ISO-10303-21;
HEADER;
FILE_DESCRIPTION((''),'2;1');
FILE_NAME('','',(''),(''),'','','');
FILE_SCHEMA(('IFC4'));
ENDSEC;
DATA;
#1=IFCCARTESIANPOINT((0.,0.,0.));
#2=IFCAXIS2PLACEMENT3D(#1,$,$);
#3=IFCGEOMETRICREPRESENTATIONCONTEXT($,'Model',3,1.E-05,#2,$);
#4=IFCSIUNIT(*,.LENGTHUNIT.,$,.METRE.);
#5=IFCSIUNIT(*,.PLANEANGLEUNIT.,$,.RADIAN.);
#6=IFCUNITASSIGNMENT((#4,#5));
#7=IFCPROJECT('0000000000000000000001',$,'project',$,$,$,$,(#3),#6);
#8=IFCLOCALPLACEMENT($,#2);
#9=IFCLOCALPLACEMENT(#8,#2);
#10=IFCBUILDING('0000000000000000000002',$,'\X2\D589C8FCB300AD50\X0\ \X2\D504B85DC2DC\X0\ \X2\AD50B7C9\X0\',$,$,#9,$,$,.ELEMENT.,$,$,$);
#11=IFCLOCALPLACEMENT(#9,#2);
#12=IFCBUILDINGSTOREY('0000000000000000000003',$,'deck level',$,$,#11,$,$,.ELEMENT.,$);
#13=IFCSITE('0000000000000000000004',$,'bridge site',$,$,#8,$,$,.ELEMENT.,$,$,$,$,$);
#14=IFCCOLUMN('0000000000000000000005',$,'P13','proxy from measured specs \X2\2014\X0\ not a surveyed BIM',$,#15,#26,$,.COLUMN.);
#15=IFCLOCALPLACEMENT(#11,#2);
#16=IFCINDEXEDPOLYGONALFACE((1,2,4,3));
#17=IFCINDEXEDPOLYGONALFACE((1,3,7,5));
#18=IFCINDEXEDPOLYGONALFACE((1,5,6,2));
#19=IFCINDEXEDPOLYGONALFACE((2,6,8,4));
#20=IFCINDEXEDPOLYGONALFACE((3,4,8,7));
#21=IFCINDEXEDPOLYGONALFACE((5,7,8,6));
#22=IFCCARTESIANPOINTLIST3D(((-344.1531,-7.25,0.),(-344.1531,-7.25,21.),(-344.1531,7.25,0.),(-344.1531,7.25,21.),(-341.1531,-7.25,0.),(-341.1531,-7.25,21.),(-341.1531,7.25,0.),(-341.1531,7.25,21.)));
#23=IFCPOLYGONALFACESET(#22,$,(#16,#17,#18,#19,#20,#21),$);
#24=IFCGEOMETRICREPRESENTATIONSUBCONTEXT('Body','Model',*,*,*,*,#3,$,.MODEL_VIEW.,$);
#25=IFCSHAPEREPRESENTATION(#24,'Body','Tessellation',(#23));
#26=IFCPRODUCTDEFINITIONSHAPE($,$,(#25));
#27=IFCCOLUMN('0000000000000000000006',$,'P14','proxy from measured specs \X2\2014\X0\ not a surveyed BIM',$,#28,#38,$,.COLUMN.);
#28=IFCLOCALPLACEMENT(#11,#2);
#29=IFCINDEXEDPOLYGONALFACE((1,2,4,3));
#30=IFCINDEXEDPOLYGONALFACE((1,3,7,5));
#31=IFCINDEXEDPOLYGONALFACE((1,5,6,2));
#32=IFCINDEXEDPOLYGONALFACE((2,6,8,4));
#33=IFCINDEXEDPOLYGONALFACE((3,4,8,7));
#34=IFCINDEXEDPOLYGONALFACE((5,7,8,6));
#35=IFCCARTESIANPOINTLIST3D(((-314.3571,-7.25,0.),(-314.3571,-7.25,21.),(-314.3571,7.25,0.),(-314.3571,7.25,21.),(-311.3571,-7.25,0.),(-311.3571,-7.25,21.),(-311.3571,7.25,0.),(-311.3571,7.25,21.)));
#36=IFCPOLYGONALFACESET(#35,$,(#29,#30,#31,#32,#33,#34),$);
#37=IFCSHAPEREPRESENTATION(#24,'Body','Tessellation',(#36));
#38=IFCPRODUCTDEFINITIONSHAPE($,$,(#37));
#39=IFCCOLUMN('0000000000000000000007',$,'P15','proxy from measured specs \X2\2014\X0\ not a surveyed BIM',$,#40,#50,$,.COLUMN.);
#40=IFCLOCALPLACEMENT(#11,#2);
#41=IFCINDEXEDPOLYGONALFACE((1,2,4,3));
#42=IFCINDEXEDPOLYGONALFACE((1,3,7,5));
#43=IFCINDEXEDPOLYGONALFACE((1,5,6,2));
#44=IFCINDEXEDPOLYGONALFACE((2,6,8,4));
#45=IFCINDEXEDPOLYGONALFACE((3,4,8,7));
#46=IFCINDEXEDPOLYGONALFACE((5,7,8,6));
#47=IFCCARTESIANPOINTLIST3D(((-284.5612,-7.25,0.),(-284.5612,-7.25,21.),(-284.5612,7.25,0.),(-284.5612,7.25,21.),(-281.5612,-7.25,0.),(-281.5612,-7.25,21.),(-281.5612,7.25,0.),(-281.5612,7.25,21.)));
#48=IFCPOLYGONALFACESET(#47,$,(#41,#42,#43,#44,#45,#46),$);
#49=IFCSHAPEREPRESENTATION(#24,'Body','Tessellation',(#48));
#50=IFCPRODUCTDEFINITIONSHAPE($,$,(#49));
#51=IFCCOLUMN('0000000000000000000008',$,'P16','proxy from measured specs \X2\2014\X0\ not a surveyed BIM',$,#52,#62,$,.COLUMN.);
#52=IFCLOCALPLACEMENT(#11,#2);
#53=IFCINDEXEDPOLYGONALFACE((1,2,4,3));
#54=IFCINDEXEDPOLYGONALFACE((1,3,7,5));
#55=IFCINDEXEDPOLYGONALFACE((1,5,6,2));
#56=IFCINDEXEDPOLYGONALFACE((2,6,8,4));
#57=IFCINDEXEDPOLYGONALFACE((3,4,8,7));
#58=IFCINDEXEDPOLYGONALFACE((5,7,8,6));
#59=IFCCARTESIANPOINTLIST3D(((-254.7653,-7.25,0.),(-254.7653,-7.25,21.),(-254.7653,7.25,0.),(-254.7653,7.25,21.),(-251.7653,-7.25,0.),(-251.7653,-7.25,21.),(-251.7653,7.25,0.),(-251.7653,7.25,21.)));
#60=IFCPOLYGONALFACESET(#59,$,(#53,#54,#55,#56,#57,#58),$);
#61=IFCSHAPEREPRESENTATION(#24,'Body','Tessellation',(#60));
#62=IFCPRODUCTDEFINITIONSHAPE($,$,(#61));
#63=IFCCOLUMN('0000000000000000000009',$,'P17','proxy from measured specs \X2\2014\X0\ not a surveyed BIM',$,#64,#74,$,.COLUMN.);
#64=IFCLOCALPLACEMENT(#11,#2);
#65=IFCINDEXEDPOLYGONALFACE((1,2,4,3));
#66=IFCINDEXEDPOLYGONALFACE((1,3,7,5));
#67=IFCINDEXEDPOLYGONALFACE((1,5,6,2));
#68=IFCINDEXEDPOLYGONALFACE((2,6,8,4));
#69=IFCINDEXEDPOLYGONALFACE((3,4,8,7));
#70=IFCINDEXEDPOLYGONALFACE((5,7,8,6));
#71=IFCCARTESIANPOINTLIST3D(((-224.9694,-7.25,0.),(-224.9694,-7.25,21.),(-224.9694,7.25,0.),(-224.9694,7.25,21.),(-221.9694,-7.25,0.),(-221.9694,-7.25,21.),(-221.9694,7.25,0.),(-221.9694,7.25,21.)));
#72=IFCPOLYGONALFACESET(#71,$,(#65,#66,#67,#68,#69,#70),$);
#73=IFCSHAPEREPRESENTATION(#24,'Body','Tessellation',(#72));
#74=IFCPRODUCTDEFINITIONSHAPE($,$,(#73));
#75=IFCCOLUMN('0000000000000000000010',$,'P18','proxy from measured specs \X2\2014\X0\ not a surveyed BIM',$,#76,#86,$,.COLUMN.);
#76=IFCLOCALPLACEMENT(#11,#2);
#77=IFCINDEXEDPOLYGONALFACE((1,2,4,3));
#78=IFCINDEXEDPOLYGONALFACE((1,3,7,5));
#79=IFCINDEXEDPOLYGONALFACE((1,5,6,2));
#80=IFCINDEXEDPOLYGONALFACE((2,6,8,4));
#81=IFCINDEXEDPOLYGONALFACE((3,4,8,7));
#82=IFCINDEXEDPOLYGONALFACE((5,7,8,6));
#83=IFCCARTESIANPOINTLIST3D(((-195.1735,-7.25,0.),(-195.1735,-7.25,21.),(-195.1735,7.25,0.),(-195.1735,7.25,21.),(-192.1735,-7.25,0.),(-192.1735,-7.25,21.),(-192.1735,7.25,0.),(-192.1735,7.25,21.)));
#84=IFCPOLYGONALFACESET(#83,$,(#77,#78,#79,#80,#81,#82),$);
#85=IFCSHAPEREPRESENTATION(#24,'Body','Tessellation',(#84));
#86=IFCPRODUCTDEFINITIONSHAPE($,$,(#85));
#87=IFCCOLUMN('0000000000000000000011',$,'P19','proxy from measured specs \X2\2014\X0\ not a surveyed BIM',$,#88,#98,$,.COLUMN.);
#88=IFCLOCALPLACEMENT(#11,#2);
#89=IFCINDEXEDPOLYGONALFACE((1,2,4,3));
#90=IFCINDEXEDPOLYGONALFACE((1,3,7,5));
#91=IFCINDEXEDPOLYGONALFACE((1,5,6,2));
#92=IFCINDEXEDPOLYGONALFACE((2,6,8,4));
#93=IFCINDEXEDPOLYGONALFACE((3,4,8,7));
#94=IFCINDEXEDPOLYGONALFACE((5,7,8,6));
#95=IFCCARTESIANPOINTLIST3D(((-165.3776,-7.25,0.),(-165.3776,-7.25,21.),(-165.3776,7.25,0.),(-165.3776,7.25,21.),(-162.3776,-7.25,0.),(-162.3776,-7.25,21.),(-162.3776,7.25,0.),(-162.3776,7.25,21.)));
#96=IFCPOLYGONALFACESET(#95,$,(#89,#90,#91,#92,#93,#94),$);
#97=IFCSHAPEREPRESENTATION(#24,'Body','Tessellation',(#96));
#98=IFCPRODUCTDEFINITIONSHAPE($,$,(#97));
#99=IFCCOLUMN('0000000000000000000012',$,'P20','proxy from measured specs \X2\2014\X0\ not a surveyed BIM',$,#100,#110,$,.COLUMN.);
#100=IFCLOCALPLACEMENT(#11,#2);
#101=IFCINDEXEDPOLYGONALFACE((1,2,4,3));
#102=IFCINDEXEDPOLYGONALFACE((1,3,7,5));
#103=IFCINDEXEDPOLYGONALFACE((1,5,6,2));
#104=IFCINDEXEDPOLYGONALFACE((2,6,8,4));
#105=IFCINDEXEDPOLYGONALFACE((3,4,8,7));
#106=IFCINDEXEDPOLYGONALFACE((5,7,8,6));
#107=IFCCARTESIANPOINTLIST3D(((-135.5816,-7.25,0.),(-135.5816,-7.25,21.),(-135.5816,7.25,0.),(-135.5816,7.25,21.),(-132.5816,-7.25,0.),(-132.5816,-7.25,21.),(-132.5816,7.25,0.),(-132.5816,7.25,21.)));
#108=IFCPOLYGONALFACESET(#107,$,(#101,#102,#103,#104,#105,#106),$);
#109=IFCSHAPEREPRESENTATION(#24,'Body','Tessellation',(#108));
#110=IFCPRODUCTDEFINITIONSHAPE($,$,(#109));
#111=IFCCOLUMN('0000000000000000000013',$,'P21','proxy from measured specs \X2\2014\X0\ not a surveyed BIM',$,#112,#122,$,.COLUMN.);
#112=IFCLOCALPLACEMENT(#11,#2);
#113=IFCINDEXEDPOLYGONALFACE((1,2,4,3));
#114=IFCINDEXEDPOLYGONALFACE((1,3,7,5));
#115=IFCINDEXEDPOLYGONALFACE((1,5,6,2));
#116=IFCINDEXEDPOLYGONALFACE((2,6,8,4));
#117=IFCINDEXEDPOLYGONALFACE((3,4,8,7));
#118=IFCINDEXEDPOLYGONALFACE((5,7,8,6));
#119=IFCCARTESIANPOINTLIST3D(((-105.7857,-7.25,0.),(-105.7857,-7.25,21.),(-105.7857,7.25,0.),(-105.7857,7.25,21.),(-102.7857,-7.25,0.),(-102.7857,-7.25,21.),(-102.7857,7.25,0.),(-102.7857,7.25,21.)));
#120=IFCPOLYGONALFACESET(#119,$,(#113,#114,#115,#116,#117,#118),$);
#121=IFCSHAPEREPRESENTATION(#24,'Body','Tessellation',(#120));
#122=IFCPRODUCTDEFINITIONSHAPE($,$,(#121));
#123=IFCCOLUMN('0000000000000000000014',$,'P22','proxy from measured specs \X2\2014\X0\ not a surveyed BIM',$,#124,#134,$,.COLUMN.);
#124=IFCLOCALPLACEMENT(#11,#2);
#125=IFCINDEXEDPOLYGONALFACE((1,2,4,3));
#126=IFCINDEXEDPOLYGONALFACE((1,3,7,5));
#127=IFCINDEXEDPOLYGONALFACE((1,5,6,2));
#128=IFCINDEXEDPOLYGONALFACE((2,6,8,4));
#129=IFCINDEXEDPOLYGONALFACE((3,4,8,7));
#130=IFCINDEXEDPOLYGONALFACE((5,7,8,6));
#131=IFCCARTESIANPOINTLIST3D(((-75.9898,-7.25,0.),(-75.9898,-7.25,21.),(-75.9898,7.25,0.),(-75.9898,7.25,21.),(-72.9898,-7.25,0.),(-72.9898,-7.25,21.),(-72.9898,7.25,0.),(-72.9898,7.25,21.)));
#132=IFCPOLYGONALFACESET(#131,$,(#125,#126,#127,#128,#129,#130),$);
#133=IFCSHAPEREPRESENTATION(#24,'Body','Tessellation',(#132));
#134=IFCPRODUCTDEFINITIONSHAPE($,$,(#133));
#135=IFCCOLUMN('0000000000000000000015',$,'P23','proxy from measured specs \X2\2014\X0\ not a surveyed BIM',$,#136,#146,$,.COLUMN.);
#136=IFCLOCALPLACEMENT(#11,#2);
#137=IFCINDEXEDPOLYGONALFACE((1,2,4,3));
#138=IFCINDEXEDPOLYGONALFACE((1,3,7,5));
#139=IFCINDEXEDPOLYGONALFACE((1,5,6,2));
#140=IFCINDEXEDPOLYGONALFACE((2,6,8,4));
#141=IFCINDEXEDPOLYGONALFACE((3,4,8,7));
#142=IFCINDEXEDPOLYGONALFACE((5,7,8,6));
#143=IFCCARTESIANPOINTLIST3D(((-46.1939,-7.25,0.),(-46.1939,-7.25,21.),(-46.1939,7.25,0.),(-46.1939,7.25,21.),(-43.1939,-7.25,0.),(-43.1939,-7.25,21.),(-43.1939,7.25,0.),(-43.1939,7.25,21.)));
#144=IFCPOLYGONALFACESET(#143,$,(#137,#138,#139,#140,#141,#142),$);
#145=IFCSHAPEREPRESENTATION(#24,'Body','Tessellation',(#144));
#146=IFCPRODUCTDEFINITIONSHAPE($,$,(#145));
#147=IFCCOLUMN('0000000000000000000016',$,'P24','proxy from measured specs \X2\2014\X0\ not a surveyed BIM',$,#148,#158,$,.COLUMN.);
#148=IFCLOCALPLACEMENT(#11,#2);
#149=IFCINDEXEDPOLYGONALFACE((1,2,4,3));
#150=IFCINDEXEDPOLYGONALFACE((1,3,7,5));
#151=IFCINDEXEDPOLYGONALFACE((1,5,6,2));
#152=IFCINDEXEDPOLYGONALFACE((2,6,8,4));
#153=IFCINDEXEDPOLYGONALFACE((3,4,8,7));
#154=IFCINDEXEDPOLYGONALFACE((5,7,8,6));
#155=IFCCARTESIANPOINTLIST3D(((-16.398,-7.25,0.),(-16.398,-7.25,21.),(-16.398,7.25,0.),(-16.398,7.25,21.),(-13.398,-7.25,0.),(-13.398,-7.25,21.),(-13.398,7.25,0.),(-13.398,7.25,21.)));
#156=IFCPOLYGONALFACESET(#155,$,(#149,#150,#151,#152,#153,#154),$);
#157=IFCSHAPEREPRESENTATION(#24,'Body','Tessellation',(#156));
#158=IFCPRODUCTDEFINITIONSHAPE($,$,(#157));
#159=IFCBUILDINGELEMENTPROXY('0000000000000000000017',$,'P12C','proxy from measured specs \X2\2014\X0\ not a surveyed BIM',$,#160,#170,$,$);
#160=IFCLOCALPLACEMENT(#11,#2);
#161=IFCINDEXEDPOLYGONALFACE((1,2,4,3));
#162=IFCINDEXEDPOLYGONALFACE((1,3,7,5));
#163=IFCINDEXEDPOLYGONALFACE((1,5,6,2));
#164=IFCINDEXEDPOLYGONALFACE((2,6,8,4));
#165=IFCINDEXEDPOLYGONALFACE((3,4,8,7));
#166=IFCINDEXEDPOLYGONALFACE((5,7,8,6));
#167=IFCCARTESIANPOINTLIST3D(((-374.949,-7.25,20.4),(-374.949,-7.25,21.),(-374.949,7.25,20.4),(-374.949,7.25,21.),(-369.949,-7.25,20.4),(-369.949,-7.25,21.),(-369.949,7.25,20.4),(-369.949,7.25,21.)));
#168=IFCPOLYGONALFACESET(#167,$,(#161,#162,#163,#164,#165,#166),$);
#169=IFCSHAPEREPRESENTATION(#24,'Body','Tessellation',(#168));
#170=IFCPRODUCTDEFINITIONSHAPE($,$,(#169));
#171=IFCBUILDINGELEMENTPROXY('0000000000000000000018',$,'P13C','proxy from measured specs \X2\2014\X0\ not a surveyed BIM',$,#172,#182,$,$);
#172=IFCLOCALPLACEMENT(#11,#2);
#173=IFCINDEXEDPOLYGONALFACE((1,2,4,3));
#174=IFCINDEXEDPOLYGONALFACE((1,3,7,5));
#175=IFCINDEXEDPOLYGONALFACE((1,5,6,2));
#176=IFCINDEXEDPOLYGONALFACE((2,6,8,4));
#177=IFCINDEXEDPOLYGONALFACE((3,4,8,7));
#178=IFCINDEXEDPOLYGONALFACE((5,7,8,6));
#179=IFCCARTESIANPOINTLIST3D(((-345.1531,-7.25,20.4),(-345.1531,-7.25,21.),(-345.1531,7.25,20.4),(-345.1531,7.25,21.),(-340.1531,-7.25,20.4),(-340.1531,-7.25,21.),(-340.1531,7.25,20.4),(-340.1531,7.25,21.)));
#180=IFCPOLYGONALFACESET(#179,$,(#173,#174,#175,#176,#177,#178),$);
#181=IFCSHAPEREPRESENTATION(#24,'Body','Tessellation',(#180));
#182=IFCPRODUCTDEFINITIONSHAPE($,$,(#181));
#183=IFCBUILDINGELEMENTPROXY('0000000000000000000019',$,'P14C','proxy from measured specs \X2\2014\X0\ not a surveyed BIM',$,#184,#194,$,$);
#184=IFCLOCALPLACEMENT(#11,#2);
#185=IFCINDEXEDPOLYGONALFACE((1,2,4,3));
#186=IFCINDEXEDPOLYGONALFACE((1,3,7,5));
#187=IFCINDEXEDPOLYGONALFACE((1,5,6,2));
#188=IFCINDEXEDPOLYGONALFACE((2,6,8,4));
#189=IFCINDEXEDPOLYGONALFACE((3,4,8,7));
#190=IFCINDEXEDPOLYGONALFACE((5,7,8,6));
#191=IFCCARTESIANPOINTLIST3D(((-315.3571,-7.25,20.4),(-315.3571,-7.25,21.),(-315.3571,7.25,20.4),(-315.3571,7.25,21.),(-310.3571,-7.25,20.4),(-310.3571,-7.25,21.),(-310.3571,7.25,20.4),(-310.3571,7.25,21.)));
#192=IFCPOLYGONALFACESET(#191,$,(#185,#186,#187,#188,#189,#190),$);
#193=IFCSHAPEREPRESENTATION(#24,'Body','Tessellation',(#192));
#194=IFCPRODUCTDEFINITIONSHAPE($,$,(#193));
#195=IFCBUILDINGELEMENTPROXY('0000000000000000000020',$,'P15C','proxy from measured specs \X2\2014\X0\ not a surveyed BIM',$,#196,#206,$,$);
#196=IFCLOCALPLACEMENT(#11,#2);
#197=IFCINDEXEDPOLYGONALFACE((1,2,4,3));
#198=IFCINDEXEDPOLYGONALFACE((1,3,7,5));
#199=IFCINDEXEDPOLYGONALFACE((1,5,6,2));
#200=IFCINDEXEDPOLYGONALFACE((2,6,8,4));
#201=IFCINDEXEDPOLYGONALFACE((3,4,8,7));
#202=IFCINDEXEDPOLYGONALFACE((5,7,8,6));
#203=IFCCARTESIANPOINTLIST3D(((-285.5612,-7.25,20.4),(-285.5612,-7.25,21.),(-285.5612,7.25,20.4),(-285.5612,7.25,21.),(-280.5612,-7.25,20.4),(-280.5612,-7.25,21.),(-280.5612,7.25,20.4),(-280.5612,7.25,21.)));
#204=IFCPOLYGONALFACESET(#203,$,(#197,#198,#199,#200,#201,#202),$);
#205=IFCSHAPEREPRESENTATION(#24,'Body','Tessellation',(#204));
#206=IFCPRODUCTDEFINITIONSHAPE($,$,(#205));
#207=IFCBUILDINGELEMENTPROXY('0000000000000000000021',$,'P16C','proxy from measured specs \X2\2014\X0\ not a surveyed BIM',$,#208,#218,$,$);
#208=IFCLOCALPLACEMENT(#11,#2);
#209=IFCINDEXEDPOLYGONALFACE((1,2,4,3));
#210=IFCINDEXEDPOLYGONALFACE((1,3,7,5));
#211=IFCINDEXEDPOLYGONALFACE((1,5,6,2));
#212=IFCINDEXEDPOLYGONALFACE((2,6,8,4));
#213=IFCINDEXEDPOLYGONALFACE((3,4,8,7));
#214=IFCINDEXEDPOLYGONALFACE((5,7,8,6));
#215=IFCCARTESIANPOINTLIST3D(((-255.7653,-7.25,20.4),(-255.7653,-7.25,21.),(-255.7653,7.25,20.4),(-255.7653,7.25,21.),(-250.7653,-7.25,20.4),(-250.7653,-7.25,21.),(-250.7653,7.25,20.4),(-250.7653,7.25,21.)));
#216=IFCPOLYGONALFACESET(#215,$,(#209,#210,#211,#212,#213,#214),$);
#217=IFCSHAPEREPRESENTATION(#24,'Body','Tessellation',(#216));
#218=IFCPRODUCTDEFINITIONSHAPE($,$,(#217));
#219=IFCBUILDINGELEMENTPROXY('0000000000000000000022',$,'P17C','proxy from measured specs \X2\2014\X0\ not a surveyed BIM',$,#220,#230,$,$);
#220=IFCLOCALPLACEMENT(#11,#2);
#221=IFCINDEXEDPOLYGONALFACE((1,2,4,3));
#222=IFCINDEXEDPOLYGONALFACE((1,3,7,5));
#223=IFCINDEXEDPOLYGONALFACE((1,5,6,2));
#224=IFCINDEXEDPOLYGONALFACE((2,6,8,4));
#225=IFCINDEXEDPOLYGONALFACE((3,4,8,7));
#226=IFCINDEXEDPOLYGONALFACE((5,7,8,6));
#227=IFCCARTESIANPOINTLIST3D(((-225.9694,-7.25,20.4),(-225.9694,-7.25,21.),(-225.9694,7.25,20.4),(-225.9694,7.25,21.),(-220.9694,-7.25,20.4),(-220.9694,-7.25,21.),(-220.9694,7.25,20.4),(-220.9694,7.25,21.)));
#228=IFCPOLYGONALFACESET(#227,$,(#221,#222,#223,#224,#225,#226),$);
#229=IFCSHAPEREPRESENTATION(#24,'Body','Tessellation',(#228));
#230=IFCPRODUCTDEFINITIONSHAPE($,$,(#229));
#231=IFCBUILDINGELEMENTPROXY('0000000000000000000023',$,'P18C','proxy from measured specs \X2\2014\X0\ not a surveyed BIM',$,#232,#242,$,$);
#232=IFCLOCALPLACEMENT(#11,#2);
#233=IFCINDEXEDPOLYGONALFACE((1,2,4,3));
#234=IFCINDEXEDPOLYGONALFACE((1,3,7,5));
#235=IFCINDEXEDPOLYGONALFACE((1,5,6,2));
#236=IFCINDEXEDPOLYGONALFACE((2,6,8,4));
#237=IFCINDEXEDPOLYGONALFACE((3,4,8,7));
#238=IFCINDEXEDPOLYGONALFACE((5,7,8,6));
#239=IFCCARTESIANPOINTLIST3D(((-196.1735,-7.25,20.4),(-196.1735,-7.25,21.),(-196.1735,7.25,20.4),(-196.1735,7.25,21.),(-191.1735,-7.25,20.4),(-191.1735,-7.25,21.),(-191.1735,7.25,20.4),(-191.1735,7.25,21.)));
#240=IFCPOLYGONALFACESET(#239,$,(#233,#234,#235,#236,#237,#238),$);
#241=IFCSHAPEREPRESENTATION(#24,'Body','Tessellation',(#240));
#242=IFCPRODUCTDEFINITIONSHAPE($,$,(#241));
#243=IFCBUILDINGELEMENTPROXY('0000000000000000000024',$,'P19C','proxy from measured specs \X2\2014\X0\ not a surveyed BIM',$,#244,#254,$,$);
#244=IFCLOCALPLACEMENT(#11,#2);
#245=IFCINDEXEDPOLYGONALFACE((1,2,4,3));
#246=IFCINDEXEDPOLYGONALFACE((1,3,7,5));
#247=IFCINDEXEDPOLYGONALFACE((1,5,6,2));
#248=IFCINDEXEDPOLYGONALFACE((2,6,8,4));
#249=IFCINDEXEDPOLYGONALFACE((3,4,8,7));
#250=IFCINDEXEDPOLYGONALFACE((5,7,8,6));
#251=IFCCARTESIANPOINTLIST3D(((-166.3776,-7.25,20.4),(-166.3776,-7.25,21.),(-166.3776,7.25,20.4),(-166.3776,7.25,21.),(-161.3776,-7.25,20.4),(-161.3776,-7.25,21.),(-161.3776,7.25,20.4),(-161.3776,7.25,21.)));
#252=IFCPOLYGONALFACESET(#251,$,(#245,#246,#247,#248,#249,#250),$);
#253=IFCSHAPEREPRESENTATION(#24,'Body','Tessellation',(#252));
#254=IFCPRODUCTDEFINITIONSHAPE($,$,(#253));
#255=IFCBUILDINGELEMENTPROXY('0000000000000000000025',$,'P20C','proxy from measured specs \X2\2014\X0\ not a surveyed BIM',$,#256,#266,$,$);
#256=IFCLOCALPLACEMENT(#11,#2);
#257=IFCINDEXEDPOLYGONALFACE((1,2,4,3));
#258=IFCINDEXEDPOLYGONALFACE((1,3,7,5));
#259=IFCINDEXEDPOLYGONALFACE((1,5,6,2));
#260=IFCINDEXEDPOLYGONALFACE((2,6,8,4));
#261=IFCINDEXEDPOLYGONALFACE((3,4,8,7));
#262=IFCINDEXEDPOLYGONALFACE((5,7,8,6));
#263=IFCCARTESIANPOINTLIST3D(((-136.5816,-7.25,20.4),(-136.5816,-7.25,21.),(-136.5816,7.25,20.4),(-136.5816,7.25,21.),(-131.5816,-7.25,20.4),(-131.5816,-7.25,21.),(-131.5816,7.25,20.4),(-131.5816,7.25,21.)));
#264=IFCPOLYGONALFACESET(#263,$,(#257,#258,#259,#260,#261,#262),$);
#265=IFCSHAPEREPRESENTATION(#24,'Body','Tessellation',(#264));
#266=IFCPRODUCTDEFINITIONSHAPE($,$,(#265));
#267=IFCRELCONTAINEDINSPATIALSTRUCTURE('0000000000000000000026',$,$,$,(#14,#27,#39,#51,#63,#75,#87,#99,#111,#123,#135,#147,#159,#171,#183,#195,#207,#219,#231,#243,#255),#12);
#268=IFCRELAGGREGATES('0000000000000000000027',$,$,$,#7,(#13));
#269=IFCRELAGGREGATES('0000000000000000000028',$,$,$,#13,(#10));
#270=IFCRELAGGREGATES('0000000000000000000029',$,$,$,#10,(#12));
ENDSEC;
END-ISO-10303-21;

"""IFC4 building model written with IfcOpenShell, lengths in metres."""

from ifc_helpers import new_model, si_unit, frame, origin, origin_2d, place, context, subcontext, project, spatial, rectangle, extrude, element, save


model = new_model("IFC4")

# Units and contexts
model_context = context("Model", 3, precision=1e-05, world=origin())
body_context = subcontext(model_context, "Body", "Model", "MODEL_VIEW")
ifc_project = project(units=[si_unit("LENGTHUNIT", "METRE"), si_unit("PLANEANGLEUNIT", "RADIAN")], contexts=[model_context])

# Site, building, storey
site_placement = place(None, origin())
site = spatial("IfcSite", under=ifc_project, at=site_placement, Name="bridge site", CompositionType="ELEMENT")
building_placement = place(site_placement, origin())
building = spatial("IfcBuilding", under=site, at=building_placement, Name="행주대교 프록시 교량", CompositionType="ELEMENT")
storey_placement = place(building_placement, origin())
storey = spatial("IfcBuildingStorey", under=building, at=storey_placement, Name="deck level", CompositionType="ELEMENT")

# Columns
for number, where, name in (
    (1, (-342.6531, 0.0, 0.0), "P13"),
    (2, (-312.8571, 0.0, 0.0), "P14"),
    (3, (-283.0612, 0.0, 0.0), "P15"),
    (4, (-253.2653, 0.0, 0.0), "P16"),
    (5, (-223.4694, 0.0, 0.0), "P17"),
    (6, (-193.6735, 0.0, 0.0), "P18"),
    (7, (-163.8776, 0.0, 0.0), "P19"),
    (8, (-134.0816, 0.0, 0.0), "P20"),
    (9, (-104.2857, 0.0, 0.0), "P21"),
    (10, (-74.4898, 0.0, 0.0), "P22"),
    (11, (-44.6939, 0.0, 0.0), "P23"),
    (12, (-14.898, 0.0, 0.0), "P24"),
):
    element("IfcColumn", number, at=place(storey_placement, frame(where)), inside=storey, Name=name, Description="proxy from measured specs — not a surveyed BIM", PredefinedType="COLUMN", context=body_context, shape_type="SweptSolid", body=[
        extrude(rectangle(XDim=3.0, YDim=14.5, at=origin_2d()), origin(), (0.0, 0.0, 1.0), 21.0),
    ])

# Building element proxies
for number, where, name in (
    (13, (-372.449, 0.0, 20.4), "P12C"),
    (14, (-342.6531, 0.0, 20.4), "P13C"),
    (15, (-312.8571, 0.0, 20.4), "P14C"),
    (16, (-283.0612, 0.0, 20.4), "P15C"),
    (17, (-253.2653, 0.0, 20.4), "P16C"),
    (18, (-223.4694, 0.0, 20.4), "P17C"),
    (19, (-193.6735, 0.0, 20.4), "P18C"),
    (20, (-163.8776, 0.0, 20.4), "P19C"),
    (21, (-134.0816, 0.0, 20.4), "P20C"),
):
    element("IfcBuildingElementProxy", number, at=place(storey_placement, frame(where)), inside=storey, Name=name, Description="proxy from measured specs — not a surveyed BIM", context=body_context, shape_type="SweptSolid", body=[
        extrude(rectangle(XDim=5.0, YDim=14.5, at=origin_2d()), origin(), (0.0, 0.0, 1.0), 0.6),
    ])

save(model, "model.ifc")
